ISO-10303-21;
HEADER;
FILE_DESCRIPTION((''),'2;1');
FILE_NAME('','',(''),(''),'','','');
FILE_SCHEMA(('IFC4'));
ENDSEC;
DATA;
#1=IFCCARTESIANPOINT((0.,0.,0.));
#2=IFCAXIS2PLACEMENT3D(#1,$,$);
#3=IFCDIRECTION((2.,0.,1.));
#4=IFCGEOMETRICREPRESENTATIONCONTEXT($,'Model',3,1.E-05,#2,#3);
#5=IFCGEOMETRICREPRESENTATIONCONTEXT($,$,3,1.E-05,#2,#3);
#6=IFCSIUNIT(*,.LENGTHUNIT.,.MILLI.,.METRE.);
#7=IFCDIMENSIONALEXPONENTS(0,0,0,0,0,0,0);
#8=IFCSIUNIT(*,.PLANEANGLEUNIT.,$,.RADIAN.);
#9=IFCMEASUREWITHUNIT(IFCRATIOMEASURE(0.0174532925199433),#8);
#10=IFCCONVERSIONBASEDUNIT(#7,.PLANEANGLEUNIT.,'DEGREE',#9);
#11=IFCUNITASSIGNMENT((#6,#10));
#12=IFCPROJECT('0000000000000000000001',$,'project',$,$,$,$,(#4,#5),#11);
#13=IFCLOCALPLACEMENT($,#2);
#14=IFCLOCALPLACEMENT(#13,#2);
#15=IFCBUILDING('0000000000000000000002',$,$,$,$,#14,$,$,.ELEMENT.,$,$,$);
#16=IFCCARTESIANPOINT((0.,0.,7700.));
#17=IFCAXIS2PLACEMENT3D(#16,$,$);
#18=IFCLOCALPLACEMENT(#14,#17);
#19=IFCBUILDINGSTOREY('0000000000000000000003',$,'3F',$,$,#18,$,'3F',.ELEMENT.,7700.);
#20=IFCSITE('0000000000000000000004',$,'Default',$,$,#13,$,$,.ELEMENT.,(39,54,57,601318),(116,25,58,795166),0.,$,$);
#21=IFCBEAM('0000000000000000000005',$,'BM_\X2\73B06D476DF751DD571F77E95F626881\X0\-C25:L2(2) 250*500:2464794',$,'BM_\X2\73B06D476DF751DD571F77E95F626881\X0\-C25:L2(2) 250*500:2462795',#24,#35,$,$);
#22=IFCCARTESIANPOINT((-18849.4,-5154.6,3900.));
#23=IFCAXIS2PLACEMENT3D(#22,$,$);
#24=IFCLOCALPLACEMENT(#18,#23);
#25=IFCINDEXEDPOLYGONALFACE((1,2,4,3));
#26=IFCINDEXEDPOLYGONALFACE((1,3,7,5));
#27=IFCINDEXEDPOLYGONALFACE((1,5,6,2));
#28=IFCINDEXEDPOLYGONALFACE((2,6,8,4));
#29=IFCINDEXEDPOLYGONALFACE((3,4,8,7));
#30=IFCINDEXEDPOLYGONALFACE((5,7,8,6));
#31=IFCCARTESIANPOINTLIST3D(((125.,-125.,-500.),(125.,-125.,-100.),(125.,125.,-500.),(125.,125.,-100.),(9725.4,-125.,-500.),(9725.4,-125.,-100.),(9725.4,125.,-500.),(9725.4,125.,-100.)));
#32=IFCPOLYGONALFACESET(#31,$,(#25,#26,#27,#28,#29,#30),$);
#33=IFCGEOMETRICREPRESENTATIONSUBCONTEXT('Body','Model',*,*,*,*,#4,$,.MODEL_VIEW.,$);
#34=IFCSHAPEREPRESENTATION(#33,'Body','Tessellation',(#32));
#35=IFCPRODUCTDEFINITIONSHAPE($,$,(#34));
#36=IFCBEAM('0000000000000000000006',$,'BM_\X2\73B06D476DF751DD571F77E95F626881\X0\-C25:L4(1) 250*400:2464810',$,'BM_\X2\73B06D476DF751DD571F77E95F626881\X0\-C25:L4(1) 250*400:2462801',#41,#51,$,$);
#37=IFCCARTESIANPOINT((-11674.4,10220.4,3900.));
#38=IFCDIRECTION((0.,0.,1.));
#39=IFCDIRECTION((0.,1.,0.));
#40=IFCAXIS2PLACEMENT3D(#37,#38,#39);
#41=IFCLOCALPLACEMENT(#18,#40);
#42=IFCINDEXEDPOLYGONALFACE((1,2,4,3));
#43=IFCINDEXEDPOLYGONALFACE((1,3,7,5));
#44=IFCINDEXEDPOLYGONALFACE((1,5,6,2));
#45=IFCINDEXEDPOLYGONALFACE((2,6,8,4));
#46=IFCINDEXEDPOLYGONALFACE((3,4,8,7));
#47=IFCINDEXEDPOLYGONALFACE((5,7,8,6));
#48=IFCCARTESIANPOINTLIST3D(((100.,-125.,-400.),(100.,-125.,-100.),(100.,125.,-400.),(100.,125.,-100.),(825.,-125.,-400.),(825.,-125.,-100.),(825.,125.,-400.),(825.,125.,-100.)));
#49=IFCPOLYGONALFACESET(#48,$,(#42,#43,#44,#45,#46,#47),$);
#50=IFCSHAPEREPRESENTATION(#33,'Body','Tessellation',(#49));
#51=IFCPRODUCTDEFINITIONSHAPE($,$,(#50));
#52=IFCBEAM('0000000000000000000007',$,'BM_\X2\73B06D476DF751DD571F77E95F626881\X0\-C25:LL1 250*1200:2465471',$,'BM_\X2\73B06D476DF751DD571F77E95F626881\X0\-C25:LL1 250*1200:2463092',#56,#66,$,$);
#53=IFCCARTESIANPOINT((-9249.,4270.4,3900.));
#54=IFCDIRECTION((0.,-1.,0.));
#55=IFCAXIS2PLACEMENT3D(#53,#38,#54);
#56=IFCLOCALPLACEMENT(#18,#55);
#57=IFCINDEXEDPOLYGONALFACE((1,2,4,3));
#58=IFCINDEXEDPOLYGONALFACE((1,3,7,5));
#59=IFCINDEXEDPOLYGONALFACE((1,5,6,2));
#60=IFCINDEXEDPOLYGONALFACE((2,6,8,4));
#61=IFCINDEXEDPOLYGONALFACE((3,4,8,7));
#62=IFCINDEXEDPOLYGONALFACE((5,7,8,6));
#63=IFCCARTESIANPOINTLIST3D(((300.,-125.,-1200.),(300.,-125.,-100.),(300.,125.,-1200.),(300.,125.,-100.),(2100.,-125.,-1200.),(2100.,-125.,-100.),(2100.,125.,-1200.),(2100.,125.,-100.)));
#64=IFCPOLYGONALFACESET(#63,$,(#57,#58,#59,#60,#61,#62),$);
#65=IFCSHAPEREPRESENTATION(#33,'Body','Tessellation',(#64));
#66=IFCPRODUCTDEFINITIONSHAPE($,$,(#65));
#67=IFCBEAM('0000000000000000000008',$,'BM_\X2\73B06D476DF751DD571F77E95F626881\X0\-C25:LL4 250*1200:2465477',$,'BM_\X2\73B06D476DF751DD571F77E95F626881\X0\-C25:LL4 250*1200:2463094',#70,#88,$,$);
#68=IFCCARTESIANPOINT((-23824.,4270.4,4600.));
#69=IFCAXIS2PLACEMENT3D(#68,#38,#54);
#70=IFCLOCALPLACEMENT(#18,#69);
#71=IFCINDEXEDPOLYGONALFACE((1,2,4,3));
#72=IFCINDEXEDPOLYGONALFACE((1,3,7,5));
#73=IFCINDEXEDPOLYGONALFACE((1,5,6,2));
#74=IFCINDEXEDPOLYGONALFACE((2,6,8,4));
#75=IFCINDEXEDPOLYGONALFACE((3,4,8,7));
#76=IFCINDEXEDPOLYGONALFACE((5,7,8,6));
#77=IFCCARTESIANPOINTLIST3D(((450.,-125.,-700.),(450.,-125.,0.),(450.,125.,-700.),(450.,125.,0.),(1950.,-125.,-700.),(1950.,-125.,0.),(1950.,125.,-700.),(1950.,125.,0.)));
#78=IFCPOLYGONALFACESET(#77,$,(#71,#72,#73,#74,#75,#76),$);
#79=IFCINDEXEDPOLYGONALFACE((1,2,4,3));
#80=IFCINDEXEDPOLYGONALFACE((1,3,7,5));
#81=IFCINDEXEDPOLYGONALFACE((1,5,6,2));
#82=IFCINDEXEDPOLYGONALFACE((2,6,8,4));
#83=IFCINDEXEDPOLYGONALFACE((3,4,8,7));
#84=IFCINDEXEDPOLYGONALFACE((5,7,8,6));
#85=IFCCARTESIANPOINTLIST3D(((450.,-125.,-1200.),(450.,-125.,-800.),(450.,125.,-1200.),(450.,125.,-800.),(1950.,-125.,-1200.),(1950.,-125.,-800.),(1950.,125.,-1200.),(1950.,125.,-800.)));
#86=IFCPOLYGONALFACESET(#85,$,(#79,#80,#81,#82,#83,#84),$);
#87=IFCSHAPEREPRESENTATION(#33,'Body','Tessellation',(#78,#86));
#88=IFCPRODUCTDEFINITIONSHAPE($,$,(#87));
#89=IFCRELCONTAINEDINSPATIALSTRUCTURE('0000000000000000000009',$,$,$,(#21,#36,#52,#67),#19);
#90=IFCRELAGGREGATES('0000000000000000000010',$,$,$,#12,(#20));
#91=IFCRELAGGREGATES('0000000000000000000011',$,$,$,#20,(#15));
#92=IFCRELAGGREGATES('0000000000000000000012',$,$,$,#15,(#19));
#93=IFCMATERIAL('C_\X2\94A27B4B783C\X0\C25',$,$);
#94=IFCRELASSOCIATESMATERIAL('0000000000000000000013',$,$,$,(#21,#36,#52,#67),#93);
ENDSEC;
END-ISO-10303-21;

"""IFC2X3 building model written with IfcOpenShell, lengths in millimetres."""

from ifc_helpers import new_model, entity, si_unit, converted_unit, direction, frame, frame_2d, origin, origin_2d_with_axis, place, context, subcontext, project, spatial, rectangle, extrude, material, element, save


model = new_model("IFC2X3")

# Units and contexts
model_context = context("Model", 3, precision=1e-05, world=origin(), true_north=direction((2.0, 0.0, 1.0)))
context_of_model = context(None, 3, precision=1e-05, world=origin(), true_north=direction((2.0, 0.0, 1.0)))
body_context = subcontext(model_context, "Body", "Model", "MODEL_VIEW")
ifc_project = project(units=[si_unit("LENGTHUNIT", "METRE", prefix="MILLI"), converted_unit("PLANEANGLEUNIT", "DEGREE", entity("IfcRatioMeasure", 0.0174532925199433), si_unit("PLANEANGLEUNIT", "RADIAN"), dimensions=[0, 0, 0, 0, 0, 0, 0])], contexts=[model_context, context_of_model])

# Site, building, storey
site_placement = place(None, origin())
site = spatial("IfcSite", under=ifc_project, at=site_placement, Name="Default", CompositionType="ELEMENT", RefLatitude=(39, 54, 57, 601318), RefLongitude=(116, 25, 58, 795166), RefElevation=0.0)
building_placement = place(site_placement, origin())
building = spatial("IfcBuilding", under=site, at=building_placement, CompositionType="ELEMENT")
storey_placement = place(building_placement, frame((0.0, 0.0, 7700.0)))
storey = spatial("IfcBuildingStorey", under=building, at=storey_placement, Name="3F", LongName="3F", CompositionType="ELEMENT", Elevation=7700.0)

# Beams
ifc_material = material(Name="C_钢筋砼C25")
beam_1_placement = place(storey_placement, frame((-18849.4, -5154.6, 3900.0)))
element("IfcBeam", 1, at=beam_1_placement, inside=storey, material=ifc_material, Name="BM_现浇混凝土矩形梁-C25:L2(2) 250*500:2464794", ObjectType="BM_现浇混凝土矩形梁-C25:L2(2) 250*500:2462795", context=body_context, shape_type="SweptSolid", body=[
    extrude(rectangle(XDim=400.0, YDim=250.0, at=frame_2d((0.0, 0.0), x_axis=(1.0, 0.0))), frame((125.0, 0.0, -300.0), z_axis=(1.0, 0.0, 0.0), x_axis=(0.0, 0.0, -1.0)), (0.0, 0.0, 1.0), 9600.4),
])
beam_2_placement = place(storey_placement, frame((-11674.4, 10220.4, 3900.0), z_axis=(0.0, 0.0, 1.0), x_axis=(0.0, 1.0, 0.0)))
element("IfcBeam", 2, at=beam_2_placement, inside=storey, material=ifc_material, Name="BM_现浇混凝土矩形梁-C25:L4(1) 250*400:2464810", ObjectType="BM_现浇混凝土矩形梁-C25:L4(1) 250*400:2462801", context=body_context, shape_type="SweptSolid", body=[
    extrude(rectangle(XDim=300.0, YDim=250.0, at=origin_2d_with_axis()), frame((100.0, 0.0, -250.0), z_axis=(1.0, 0.0, 0.0), x_axis=(0.0, 0.0, -1.0)), (0.0, 0.0, 1.0), 725.0),
])
beam_3_placement = place(storey_placement, frame((-9249.0, 4270.4, 3900.0), z_axis=(0.0, 0.0, 1.0), x_axis=(0.0, -1.0, 0.0)))
element("IfcBeam", 3, at=beam_3_placement, inside=storey, material=ifc_material, Name="BM_现浇混凝土矩形梁-C25:LL1 250*1200:2465471", ObjectType="BM_现浇混凝土矩形梁-C25:LL1 250*1200:2463092", context=body_context, shape_type="SweptSolid", body=[
    extrude(rectangle(XDim=1100.0, YDim=250.0, at=frame_2d((0.0, 0.0), x_axis=(1.0, 0.0))), frame((300.0, 0.0, -650.0), z_axis=(1.0, 0.0, 0.0), x_axis=(0.0, 0.0, -1.0)), (0.0, 0.0, 1.0), 1800.0),
])
beam_4_placement = place(storey_placement, frame((-23824.0, 4270.4, 4600.0), z_axis=(0.0, 0.0, 1.0), x_axis=(0.0, -1.0, 0.0)))
element("IfcBeam", 4, at=beam_4_placement, inside=storey, material=ifc_material, Name="BM_现浇混凝土矩形梁-C25:LL4 250*1200:2465477", ObjectType="BM_现浇混凝土矩形梁-C25:LL4 250*1200:2463094", context=body_context, shape_type="SweptSolid", body=[
    extrude(rectangle(XDim=700.0, YDim=250.0, at=frame_2d((0.0, 0.0), x_axis=(1.0, 0.0))), frame((450.0, 0.0, -350.0), z_axis=(1.0, 0.0, 0.0), x_axis=(0.0, 0.0, -1.0)), (0.0, 0.0, 1.0), 1500.0),
    extrude(rectangle(XDim=400.0, YDim=250.0, at=frame_2d((0.0, 0.0), x_axis=(1.0, 0.0))), frame((450.0, 0.0, -1000.0), z_axis=(1.0, 0.0, 0.0), x_axis=(0.0, 0.0, 1.0)), (0.0, 0.0, 1.0), 1500.0),
])

save(model, "model.ifc")
